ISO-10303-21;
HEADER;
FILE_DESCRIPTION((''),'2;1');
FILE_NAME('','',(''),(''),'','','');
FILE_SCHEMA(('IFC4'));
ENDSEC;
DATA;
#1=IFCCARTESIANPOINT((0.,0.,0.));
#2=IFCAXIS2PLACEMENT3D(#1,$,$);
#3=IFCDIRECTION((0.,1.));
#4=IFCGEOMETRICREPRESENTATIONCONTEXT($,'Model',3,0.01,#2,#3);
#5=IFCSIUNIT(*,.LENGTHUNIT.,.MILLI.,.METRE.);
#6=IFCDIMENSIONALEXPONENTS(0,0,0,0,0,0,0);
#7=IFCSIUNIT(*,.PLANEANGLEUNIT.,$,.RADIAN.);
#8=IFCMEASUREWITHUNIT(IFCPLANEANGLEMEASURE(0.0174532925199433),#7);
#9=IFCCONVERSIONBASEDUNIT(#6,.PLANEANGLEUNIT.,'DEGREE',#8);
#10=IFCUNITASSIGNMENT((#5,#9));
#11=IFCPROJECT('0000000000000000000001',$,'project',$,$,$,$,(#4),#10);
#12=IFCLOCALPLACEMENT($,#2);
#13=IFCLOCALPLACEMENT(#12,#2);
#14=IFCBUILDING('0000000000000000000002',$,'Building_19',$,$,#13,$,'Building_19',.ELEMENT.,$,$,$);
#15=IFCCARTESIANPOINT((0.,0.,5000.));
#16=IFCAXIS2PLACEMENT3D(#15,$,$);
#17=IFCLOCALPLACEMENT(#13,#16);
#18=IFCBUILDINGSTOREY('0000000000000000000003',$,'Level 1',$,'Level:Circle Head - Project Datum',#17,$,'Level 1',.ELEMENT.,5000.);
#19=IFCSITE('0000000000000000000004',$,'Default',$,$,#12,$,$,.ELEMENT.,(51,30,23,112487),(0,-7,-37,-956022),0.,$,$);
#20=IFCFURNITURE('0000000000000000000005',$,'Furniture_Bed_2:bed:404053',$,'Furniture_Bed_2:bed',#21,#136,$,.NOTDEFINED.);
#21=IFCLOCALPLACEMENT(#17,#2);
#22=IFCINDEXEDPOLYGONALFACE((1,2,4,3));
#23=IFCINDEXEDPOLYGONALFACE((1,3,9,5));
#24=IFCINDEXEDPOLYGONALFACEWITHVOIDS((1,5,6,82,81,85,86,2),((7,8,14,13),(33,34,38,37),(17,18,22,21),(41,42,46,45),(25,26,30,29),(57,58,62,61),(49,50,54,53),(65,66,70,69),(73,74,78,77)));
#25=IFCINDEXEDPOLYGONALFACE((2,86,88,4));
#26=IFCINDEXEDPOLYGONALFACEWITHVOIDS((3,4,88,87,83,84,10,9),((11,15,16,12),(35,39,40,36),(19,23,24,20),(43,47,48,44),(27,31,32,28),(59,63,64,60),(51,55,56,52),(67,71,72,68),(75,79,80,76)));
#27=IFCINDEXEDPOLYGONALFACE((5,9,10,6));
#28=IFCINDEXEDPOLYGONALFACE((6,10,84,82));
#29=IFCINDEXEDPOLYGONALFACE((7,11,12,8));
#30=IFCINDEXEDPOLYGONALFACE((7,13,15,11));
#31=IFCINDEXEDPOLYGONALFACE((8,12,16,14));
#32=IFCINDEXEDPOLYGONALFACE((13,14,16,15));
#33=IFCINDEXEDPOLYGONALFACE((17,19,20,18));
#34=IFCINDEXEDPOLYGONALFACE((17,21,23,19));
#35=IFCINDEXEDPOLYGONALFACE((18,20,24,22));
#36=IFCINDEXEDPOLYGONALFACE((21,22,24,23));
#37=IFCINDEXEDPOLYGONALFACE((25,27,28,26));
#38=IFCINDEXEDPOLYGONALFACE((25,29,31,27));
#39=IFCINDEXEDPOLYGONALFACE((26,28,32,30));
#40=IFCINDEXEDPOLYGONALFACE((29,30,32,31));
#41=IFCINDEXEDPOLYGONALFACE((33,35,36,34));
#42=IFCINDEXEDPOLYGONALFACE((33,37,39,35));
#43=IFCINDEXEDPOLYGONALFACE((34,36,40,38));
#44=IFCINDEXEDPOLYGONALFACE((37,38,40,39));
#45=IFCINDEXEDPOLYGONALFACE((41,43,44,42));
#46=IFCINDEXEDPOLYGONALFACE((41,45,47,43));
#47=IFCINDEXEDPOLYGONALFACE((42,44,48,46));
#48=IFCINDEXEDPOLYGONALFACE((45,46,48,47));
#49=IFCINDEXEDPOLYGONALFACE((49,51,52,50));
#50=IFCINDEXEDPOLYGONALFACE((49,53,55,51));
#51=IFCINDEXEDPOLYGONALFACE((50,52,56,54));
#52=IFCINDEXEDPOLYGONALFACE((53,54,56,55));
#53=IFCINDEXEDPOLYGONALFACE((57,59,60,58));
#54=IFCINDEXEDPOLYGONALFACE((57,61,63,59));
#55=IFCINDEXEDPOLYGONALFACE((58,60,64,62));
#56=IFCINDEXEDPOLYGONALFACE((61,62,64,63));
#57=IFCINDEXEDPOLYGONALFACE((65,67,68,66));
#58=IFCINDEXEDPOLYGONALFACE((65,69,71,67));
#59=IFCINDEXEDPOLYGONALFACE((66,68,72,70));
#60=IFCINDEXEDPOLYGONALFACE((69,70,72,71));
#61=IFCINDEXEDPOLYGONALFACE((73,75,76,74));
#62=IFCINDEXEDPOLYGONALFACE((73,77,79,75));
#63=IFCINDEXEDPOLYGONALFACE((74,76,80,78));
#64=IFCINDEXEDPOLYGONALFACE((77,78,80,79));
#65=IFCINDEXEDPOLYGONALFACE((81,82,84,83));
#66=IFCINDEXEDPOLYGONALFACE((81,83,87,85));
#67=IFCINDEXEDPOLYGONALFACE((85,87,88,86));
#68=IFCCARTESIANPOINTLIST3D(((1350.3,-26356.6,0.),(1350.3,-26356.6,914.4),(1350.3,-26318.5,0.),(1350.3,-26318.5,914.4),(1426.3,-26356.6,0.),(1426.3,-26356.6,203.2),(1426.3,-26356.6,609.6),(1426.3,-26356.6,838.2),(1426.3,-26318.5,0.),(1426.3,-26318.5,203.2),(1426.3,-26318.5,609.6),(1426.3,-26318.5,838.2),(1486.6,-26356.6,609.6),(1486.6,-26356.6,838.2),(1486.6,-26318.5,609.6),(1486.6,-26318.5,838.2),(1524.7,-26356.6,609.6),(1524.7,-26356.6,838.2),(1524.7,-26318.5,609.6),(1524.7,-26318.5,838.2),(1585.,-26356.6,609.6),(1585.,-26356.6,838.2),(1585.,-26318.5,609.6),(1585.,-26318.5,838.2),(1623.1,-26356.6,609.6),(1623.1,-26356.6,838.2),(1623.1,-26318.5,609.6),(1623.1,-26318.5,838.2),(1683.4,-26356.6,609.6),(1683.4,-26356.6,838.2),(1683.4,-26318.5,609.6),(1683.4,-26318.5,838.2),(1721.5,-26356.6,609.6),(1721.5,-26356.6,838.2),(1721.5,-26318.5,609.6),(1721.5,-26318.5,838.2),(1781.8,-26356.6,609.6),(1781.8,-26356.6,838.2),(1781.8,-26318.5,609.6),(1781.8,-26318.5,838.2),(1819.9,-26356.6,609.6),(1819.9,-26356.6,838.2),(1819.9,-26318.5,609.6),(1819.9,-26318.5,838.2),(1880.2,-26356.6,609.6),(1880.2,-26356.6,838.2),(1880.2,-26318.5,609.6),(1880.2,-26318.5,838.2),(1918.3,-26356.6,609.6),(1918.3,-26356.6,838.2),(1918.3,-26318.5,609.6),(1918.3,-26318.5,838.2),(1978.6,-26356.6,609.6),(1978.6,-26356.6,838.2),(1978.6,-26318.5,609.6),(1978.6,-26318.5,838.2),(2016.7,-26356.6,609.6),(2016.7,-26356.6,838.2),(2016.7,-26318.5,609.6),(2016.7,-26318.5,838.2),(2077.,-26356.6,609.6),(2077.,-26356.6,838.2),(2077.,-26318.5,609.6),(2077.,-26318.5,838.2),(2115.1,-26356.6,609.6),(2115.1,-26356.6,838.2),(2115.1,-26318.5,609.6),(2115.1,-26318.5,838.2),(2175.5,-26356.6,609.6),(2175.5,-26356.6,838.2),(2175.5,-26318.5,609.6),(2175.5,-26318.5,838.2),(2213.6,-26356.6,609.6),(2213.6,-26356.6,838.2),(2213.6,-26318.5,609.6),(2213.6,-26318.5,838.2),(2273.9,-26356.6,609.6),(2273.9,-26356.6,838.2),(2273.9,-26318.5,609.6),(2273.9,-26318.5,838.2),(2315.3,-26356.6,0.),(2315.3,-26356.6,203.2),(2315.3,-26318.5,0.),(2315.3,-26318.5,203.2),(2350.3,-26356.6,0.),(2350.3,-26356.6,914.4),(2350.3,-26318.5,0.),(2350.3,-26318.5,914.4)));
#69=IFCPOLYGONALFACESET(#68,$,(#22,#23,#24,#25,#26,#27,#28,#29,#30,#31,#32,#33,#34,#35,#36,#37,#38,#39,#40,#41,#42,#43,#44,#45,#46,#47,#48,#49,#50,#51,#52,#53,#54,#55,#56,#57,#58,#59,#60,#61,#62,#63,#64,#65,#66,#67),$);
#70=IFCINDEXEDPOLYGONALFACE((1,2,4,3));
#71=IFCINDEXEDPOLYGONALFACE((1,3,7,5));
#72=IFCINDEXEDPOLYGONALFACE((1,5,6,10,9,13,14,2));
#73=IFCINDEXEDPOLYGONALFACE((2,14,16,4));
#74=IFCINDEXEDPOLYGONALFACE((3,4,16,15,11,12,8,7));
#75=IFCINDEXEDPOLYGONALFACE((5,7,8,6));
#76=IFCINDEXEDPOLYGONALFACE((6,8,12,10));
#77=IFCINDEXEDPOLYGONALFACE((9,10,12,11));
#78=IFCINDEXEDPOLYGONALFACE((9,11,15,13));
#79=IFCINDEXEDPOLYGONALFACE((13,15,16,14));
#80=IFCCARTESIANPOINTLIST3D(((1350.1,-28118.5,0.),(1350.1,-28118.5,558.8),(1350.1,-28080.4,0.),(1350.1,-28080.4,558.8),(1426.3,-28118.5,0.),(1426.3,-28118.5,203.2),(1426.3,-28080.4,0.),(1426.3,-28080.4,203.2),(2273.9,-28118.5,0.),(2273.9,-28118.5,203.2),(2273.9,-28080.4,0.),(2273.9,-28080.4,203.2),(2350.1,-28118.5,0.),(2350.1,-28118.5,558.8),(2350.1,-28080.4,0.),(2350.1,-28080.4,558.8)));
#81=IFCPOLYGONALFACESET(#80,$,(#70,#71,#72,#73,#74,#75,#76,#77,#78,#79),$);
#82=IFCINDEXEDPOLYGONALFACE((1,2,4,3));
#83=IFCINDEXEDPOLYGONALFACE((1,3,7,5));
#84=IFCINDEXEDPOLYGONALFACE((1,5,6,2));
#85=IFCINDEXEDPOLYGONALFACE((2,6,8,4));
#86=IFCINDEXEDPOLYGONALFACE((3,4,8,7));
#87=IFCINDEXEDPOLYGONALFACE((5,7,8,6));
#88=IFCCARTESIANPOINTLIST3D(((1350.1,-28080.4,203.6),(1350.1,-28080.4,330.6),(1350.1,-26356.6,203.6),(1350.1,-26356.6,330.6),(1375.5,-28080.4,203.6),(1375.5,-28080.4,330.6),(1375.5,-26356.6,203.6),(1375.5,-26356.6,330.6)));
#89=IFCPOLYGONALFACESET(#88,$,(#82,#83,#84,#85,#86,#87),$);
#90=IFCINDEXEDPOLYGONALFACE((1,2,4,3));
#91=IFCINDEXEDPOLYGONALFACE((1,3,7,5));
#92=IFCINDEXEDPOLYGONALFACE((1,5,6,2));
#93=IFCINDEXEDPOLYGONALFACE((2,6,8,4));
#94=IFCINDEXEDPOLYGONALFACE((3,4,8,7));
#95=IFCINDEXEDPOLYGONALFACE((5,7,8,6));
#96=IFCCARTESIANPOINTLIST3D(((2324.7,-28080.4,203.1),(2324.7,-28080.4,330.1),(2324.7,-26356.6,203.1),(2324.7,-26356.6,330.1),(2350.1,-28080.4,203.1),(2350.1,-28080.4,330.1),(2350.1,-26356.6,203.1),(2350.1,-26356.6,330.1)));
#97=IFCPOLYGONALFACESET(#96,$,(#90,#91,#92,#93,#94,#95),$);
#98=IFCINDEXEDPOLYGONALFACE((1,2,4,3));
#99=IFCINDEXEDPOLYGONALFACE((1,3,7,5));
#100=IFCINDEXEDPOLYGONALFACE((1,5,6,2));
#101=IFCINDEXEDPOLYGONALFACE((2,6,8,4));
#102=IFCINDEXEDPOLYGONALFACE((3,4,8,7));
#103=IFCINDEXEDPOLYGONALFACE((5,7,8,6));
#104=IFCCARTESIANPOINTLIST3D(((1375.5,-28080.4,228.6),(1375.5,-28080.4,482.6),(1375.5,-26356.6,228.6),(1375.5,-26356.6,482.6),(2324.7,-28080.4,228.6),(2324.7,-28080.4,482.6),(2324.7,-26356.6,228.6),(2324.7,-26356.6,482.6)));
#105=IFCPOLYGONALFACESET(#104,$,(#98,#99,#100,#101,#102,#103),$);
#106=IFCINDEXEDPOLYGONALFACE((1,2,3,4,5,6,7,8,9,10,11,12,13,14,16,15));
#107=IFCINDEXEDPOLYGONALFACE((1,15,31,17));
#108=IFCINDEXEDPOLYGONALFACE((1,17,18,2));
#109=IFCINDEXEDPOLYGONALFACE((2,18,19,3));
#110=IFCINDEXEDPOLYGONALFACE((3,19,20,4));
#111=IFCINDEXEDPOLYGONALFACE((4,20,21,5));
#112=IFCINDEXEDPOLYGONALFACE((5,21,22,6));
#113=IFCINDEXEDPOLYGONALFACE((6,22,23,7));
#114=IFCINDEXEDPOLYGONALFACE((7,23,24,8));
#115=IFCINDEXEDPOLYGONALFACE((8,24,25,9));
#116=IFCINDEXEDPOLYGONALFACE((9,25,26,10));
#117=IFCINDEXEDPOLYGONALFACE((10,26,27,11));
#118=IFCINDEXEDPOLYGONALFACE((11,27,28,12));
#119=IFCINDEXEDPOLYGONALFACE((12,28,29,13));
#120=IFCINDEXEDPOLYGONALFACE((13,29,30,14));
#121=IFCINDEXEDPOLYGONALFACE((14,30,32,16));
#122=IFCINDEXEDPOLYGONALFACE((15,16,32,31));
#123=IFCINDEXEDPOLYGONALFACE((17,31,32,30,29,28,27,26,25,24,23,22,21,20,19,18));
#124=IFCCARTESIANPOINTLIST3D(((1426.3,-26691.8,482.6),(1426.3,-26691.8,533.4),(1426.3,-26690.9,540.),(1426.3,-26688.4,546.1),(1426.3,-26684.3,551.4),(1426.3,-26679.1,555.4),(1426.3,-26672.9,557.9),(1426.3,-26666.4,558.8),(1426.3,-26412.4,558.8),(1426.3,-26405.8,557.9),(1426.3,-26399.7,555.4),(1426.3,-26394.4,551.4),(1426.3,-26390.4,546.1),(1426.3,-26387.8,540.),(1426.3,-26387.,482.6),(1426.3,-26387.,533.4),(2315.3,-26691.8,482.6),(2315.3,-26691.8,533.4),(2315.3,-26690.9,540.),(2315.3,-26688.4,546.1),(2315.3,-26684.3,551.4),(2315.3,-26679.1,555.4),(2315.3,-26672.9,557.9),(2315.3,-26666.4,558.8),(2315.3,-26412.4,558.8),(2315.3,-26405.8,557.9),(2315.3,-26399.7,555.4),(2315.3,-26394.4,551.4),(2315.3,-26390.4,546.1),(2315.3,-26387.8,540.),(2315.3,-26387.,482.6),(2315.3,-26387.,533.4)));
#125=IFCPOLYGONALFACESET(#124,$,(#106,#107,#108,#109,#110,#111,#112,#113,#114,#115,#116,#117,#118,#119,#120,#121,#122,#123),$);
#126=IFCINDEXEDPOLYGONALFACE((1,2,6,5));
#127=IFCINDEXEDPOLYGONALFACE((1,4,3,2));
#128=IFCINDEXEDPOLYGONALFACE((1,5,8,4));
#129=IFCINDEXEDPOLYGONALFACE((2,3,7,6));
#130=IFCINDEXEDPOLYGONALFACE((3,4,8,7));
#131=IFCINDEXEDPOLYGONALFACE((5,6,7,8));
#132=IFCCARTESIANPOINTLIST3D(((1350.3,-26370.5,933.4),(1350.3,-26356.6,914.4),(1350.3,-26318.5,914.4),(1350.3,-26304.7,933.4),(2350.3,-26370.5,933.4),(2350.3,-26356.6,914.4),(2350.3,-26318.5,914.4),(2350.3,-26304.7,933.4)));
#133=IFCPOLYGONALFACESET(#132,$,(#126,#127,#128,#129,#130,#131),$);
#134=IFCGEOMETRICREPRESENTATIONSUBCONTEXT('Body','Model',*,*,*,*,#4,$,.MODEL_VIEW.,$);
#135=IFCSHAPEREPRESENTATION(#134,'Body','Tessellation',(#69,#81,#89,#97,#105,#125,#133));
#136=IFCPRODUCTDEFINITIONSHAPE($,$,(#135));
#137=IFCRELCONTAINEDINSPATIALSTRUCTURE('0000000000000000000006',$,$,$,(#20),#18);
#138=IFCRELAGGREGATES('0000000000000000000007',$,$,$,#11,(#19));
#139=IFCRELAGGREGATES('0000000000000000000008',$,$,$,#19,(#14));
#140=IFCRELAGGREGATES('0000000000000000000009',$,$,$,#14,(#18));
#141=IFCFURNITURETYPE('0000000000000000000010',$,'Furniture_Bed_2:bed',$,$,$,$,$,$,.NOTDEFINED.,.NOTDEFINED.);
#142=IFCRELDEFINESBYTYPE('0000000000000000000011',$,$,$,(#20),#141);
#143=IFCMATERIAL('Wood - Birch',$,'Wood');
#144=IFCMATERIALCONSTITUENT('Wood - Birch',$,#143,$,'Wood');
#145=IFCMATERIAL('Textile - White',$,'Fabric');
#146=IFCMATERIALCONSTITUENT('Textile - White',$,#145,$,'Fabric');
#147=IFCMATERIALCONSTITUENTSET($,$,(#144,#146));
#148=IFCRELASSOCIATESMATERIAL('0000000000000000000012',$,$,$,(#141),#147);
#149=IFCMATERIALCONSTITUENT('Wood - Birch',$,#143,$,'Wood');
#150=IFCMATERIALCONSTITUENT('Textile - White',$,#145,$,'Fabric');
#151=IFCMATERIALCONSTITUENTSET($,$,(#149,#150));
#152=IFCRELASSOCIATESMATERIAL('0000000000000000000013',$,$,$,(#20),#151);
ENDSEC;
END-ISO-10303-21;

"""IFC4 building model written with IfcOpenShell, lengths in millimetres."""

from ifc_helpers import new_model, entity, si_unit, converted_unit, direction, frame, origin, place, context, subcontext, project, spatial, line, arc, indexed_curve, outline, extrude, source, transform, mapped, material, constituent, constituent_set, type_object, type_shapes, element, save


model = new_model("IFC4")

# Units and contexts
model_context = context("Model", 3, precision=0.01, world=origin(), true_north=direction((0.0, 1.0)))
body_context = subcontext(model_context, "Body", "Model", "MODEL_VIEW")
ifc_project = project(units=[si_unit("LENGTHUNIT", "METRE", prefix="MILLI"), converted_unit("PLANEANGLEUNIT", "DEGREE", entity("IfcPlaneAngleMeasure", 0.0174532925199433), si_unit("PLANEANGLEUNIT", "RADIAN"), dimensions=[0, 0, 0, 0, 0, 0, 0])], contexts=[model_context])

# Site, building, storey
site_placement = place(None, origin())
site = spatial("IfcSite", under=ifc_project, at=site_placement, Name="Default", CompositionType="ELEMENT", RefLatitude=(51, 30, 23, 112487), RefLongitude=(0, -7, -37, -956022), RefElevation=0.0)
building_placement = place(site_placement, origin())
building = spatial("IfcBuilding", under=site, at=building_placement, Name="Building_19", LongName="Building_19", CompositionType="ELEMENT")
storey_placement = place(building_placement, frame((0.0, 0.0, 5000.0)))
storey = spatial("IfcBuildingStorey", under=building, at=storey_placement, Name="Level 1", ObjectType="Level:Circle Head - Project Datum", LongName="Level 1", CompositionType="ELEMENT", Elevation=5000.0)

# Furniture
ifc_material_1 = material(Name="Wood - Birch", Category="Wood")
ifc_material_2 = material(Name="Textile - White", Category="Fabric")
ifc_constituent_1 = constituent(ifc_material_1, Name="Wood - Birch", Category="Wood")
ifc_constituent_2 = constituent(ifc_material_2, Name="Textile - White", Category="Fabric")
ifc_constituent_set_1 = constituent_set(constituents=[ifc_constituent_1, ifc_constituent_2])
furniture_type_1 = type_object("IfcFurnitureType", Name="Furniture_Bed_2:bed", AssemblyPlace="NOTDEFINED", PredefinedType="NOTDEFINED", material=ifc_constituent_set_1)
shared_shape_1 = source(origin(), body_context, "Body", "SweptSolid", [
    extrude(outline(indexed_curve([(-635.0, -489.8), (279.4, -489.8), (279.4, -454.7), (76.2, -454.7), (76.2, 434.3), (279.4, 434.3), (279.4, 510.3), (-635.0, 510.3), (-635.0, -489.8)], self_intersect=False), holes=[indexed_curve([(-558.8, 374.0), (-558.8, 434.3), (-330.2, 434.3), (-330.2, 374.0), (-558.8, 374.0)], self_intersect=False), indexed_curve([(-558.8, 275.5), (-558.8, 335.9), (-330.2, 335.9), (-330.2, 275.5), (-558.8, 275.5)], self_intersect=False), indexed_curve([(-558.8, 177.1), (-558.8, 237.4), (-330.2, 237.4), (-330.2, 177.1), (-558.8, 177.1)], self_intersect=False), indexed_curve([(-558.8, 78.7), (-558.8, 139.0), (-330.2, 139.0), (-330.2, 78.7), (-558.8, 78.7)], self_intersect=False), indexed_curve([(-558.8, -118.1), (-558.8, -57.8), (-330.2, -57.8), (-330.2, -118.1), (-558.8, -118.1)], self_intersect=False), indexed_curve([(-558.8, -216.5), (-558.8, -156.2), (-330.2, -156.2), (-330.2, -216.5), (-558.8, -216.5)], self_intersect=False), indexed_curve([(-558.8, -314.9), (-558.8, -254.6), (-330.2, -254.6), (-330.2, -314.9), (-558.8, -314.9)], self_intersect=False), indexed_curve([(-558.8, -413.3), (-558.8, -353.0), (-330.2, -353.0), (-330.2, -413.3), (-558.8, -413.3)], self_intersect=False), indexed_curve([(-558.8, -19.7), (-558.8, 40.6), (-330.2, 40.6), (-330.2, -19.7), (-558.8, -19.7)], self_intersect=False)]), frame((-8.6, -38.1, 279.4), z_axis=(0.0, 1.0, 0.0), x_axis=(0.0, 0.0, -1.0)), (0.0, 0.0, 1.0), 38.1),
    extrude(outline(indexed_curve([(423.8, -190.5), (500.0, -190.5), (500.0, 368.3), (-500.0, 368.3), (-500.0, -190.5), (-423.8, -190.5), (-423.8, 12.7), (423.8, 12.7), (423.8, -190.5)], self_intersect=False)), frame((-19.1, -1800.0, 190.5), z_axis=(0.0, 1.0, 0.0), x_axis=(-1.0, 0.0, 0.0)), (0.0, 0.0, 1.0), 38.1),
    extrude(outline(indexed_curve([(-12.7, -861.9), (12.7, -861.9), (12.7, 861.9), (-12.7, 861.9), (-12.7, -861.9)], self_intersect=False)), frame((-506.4, -900.0, 203.6)), (0.0, 0.0, 1.0), 127.0),
    extrude(outline(indexed_curve([(-12.7, -861.9), (12.7, -861.9), (12.7, 861.9), (-12.7, 861.9), (-12.7, -861.9)], self_intersect=False)), frame((468.2, -900.0, 203.1)), (0.0, 0.0, 1.0), 127.0),
    extrude(outline(indexed_curve([(-474.6, -861.9), (474.6, -861.9), (474.6, 861.9), (-474.6, 861.9), (-474.6, -861.9)], self_intersect=False)), frame((-19.0, -900.0, 228.6), z_axis=(0.0, 0.0, 1.0), x_axis=(-1.0, 0.0, 0.0)), (0.0, 0.0, 1.0), 254.0),
    extrude(outline(indexed_curve([(-152.4, -42.3), (152.4, -42.3), (152.4, 8.5), (145.0, 26.4), (127.0, 33.9), (-127.0, 33.9), (-145.0, 26.4), (-152.4, 8.5)], segments=[line(1, 2, 3), arc(3, 4, 5), line(5, 6), arc(6, 7, 8), line(8, 1)], self_intersect=False)), frame((-442.9, -220.8, 524.9), z_axis=(1.0, 0.0, 0.0), x_axis=(0.0, 1.0, 0.0)), (0.0, 0.0, 1.0), 889.0),
    extrude(outline(indexed_curve([(-19.1, -9.5), (19.0, -9.5), (32.9, 9.5), (-32.9, 9.5), (-19.1, -9.5)], self_intersect=False)), frame((-518.8, -19.0, 923.9), z_axis=(1.0, 0.0, 0.0), x_axis=(0.0, 1.0, 0.0)), (0.0, 0.0, 1.0), 1000.1),
])
type_shapes(furniture_type_1, [shared_shape_1])
ifc_constituent_3 = constituent(ifc_material_1, Name="Wood - Birch", Category="Wood")
ifc_constituent_4 = constituent(ifc_material_2, Name="Textile - White", Category="Fabric")
ifc_constituent_set_2 = constituent_set(constituents=[ifc_constituent_3, ifc_constituent_4])
furniture_1_placement = place(storey_placement, frame((1869.1, -26318.5, 0.0)))
element("IfcFurniture", 1, at=furniture_1_placement, inside=storey, type_object=furniture_type_1, material=ifc_constituent_set_2, Name="Furniture_Bed_2:bed:404053", ObjectType="Furniture_Bed_2:bed", PredefinedType="NOTDEFINED", context=body_context, shape_type="MappedRepresentation", body=[
    mapped(shared_shape_1, transform((0.0, 0.0, 0.0), scale=1.0)),
])

save(model, "model.ifc")
